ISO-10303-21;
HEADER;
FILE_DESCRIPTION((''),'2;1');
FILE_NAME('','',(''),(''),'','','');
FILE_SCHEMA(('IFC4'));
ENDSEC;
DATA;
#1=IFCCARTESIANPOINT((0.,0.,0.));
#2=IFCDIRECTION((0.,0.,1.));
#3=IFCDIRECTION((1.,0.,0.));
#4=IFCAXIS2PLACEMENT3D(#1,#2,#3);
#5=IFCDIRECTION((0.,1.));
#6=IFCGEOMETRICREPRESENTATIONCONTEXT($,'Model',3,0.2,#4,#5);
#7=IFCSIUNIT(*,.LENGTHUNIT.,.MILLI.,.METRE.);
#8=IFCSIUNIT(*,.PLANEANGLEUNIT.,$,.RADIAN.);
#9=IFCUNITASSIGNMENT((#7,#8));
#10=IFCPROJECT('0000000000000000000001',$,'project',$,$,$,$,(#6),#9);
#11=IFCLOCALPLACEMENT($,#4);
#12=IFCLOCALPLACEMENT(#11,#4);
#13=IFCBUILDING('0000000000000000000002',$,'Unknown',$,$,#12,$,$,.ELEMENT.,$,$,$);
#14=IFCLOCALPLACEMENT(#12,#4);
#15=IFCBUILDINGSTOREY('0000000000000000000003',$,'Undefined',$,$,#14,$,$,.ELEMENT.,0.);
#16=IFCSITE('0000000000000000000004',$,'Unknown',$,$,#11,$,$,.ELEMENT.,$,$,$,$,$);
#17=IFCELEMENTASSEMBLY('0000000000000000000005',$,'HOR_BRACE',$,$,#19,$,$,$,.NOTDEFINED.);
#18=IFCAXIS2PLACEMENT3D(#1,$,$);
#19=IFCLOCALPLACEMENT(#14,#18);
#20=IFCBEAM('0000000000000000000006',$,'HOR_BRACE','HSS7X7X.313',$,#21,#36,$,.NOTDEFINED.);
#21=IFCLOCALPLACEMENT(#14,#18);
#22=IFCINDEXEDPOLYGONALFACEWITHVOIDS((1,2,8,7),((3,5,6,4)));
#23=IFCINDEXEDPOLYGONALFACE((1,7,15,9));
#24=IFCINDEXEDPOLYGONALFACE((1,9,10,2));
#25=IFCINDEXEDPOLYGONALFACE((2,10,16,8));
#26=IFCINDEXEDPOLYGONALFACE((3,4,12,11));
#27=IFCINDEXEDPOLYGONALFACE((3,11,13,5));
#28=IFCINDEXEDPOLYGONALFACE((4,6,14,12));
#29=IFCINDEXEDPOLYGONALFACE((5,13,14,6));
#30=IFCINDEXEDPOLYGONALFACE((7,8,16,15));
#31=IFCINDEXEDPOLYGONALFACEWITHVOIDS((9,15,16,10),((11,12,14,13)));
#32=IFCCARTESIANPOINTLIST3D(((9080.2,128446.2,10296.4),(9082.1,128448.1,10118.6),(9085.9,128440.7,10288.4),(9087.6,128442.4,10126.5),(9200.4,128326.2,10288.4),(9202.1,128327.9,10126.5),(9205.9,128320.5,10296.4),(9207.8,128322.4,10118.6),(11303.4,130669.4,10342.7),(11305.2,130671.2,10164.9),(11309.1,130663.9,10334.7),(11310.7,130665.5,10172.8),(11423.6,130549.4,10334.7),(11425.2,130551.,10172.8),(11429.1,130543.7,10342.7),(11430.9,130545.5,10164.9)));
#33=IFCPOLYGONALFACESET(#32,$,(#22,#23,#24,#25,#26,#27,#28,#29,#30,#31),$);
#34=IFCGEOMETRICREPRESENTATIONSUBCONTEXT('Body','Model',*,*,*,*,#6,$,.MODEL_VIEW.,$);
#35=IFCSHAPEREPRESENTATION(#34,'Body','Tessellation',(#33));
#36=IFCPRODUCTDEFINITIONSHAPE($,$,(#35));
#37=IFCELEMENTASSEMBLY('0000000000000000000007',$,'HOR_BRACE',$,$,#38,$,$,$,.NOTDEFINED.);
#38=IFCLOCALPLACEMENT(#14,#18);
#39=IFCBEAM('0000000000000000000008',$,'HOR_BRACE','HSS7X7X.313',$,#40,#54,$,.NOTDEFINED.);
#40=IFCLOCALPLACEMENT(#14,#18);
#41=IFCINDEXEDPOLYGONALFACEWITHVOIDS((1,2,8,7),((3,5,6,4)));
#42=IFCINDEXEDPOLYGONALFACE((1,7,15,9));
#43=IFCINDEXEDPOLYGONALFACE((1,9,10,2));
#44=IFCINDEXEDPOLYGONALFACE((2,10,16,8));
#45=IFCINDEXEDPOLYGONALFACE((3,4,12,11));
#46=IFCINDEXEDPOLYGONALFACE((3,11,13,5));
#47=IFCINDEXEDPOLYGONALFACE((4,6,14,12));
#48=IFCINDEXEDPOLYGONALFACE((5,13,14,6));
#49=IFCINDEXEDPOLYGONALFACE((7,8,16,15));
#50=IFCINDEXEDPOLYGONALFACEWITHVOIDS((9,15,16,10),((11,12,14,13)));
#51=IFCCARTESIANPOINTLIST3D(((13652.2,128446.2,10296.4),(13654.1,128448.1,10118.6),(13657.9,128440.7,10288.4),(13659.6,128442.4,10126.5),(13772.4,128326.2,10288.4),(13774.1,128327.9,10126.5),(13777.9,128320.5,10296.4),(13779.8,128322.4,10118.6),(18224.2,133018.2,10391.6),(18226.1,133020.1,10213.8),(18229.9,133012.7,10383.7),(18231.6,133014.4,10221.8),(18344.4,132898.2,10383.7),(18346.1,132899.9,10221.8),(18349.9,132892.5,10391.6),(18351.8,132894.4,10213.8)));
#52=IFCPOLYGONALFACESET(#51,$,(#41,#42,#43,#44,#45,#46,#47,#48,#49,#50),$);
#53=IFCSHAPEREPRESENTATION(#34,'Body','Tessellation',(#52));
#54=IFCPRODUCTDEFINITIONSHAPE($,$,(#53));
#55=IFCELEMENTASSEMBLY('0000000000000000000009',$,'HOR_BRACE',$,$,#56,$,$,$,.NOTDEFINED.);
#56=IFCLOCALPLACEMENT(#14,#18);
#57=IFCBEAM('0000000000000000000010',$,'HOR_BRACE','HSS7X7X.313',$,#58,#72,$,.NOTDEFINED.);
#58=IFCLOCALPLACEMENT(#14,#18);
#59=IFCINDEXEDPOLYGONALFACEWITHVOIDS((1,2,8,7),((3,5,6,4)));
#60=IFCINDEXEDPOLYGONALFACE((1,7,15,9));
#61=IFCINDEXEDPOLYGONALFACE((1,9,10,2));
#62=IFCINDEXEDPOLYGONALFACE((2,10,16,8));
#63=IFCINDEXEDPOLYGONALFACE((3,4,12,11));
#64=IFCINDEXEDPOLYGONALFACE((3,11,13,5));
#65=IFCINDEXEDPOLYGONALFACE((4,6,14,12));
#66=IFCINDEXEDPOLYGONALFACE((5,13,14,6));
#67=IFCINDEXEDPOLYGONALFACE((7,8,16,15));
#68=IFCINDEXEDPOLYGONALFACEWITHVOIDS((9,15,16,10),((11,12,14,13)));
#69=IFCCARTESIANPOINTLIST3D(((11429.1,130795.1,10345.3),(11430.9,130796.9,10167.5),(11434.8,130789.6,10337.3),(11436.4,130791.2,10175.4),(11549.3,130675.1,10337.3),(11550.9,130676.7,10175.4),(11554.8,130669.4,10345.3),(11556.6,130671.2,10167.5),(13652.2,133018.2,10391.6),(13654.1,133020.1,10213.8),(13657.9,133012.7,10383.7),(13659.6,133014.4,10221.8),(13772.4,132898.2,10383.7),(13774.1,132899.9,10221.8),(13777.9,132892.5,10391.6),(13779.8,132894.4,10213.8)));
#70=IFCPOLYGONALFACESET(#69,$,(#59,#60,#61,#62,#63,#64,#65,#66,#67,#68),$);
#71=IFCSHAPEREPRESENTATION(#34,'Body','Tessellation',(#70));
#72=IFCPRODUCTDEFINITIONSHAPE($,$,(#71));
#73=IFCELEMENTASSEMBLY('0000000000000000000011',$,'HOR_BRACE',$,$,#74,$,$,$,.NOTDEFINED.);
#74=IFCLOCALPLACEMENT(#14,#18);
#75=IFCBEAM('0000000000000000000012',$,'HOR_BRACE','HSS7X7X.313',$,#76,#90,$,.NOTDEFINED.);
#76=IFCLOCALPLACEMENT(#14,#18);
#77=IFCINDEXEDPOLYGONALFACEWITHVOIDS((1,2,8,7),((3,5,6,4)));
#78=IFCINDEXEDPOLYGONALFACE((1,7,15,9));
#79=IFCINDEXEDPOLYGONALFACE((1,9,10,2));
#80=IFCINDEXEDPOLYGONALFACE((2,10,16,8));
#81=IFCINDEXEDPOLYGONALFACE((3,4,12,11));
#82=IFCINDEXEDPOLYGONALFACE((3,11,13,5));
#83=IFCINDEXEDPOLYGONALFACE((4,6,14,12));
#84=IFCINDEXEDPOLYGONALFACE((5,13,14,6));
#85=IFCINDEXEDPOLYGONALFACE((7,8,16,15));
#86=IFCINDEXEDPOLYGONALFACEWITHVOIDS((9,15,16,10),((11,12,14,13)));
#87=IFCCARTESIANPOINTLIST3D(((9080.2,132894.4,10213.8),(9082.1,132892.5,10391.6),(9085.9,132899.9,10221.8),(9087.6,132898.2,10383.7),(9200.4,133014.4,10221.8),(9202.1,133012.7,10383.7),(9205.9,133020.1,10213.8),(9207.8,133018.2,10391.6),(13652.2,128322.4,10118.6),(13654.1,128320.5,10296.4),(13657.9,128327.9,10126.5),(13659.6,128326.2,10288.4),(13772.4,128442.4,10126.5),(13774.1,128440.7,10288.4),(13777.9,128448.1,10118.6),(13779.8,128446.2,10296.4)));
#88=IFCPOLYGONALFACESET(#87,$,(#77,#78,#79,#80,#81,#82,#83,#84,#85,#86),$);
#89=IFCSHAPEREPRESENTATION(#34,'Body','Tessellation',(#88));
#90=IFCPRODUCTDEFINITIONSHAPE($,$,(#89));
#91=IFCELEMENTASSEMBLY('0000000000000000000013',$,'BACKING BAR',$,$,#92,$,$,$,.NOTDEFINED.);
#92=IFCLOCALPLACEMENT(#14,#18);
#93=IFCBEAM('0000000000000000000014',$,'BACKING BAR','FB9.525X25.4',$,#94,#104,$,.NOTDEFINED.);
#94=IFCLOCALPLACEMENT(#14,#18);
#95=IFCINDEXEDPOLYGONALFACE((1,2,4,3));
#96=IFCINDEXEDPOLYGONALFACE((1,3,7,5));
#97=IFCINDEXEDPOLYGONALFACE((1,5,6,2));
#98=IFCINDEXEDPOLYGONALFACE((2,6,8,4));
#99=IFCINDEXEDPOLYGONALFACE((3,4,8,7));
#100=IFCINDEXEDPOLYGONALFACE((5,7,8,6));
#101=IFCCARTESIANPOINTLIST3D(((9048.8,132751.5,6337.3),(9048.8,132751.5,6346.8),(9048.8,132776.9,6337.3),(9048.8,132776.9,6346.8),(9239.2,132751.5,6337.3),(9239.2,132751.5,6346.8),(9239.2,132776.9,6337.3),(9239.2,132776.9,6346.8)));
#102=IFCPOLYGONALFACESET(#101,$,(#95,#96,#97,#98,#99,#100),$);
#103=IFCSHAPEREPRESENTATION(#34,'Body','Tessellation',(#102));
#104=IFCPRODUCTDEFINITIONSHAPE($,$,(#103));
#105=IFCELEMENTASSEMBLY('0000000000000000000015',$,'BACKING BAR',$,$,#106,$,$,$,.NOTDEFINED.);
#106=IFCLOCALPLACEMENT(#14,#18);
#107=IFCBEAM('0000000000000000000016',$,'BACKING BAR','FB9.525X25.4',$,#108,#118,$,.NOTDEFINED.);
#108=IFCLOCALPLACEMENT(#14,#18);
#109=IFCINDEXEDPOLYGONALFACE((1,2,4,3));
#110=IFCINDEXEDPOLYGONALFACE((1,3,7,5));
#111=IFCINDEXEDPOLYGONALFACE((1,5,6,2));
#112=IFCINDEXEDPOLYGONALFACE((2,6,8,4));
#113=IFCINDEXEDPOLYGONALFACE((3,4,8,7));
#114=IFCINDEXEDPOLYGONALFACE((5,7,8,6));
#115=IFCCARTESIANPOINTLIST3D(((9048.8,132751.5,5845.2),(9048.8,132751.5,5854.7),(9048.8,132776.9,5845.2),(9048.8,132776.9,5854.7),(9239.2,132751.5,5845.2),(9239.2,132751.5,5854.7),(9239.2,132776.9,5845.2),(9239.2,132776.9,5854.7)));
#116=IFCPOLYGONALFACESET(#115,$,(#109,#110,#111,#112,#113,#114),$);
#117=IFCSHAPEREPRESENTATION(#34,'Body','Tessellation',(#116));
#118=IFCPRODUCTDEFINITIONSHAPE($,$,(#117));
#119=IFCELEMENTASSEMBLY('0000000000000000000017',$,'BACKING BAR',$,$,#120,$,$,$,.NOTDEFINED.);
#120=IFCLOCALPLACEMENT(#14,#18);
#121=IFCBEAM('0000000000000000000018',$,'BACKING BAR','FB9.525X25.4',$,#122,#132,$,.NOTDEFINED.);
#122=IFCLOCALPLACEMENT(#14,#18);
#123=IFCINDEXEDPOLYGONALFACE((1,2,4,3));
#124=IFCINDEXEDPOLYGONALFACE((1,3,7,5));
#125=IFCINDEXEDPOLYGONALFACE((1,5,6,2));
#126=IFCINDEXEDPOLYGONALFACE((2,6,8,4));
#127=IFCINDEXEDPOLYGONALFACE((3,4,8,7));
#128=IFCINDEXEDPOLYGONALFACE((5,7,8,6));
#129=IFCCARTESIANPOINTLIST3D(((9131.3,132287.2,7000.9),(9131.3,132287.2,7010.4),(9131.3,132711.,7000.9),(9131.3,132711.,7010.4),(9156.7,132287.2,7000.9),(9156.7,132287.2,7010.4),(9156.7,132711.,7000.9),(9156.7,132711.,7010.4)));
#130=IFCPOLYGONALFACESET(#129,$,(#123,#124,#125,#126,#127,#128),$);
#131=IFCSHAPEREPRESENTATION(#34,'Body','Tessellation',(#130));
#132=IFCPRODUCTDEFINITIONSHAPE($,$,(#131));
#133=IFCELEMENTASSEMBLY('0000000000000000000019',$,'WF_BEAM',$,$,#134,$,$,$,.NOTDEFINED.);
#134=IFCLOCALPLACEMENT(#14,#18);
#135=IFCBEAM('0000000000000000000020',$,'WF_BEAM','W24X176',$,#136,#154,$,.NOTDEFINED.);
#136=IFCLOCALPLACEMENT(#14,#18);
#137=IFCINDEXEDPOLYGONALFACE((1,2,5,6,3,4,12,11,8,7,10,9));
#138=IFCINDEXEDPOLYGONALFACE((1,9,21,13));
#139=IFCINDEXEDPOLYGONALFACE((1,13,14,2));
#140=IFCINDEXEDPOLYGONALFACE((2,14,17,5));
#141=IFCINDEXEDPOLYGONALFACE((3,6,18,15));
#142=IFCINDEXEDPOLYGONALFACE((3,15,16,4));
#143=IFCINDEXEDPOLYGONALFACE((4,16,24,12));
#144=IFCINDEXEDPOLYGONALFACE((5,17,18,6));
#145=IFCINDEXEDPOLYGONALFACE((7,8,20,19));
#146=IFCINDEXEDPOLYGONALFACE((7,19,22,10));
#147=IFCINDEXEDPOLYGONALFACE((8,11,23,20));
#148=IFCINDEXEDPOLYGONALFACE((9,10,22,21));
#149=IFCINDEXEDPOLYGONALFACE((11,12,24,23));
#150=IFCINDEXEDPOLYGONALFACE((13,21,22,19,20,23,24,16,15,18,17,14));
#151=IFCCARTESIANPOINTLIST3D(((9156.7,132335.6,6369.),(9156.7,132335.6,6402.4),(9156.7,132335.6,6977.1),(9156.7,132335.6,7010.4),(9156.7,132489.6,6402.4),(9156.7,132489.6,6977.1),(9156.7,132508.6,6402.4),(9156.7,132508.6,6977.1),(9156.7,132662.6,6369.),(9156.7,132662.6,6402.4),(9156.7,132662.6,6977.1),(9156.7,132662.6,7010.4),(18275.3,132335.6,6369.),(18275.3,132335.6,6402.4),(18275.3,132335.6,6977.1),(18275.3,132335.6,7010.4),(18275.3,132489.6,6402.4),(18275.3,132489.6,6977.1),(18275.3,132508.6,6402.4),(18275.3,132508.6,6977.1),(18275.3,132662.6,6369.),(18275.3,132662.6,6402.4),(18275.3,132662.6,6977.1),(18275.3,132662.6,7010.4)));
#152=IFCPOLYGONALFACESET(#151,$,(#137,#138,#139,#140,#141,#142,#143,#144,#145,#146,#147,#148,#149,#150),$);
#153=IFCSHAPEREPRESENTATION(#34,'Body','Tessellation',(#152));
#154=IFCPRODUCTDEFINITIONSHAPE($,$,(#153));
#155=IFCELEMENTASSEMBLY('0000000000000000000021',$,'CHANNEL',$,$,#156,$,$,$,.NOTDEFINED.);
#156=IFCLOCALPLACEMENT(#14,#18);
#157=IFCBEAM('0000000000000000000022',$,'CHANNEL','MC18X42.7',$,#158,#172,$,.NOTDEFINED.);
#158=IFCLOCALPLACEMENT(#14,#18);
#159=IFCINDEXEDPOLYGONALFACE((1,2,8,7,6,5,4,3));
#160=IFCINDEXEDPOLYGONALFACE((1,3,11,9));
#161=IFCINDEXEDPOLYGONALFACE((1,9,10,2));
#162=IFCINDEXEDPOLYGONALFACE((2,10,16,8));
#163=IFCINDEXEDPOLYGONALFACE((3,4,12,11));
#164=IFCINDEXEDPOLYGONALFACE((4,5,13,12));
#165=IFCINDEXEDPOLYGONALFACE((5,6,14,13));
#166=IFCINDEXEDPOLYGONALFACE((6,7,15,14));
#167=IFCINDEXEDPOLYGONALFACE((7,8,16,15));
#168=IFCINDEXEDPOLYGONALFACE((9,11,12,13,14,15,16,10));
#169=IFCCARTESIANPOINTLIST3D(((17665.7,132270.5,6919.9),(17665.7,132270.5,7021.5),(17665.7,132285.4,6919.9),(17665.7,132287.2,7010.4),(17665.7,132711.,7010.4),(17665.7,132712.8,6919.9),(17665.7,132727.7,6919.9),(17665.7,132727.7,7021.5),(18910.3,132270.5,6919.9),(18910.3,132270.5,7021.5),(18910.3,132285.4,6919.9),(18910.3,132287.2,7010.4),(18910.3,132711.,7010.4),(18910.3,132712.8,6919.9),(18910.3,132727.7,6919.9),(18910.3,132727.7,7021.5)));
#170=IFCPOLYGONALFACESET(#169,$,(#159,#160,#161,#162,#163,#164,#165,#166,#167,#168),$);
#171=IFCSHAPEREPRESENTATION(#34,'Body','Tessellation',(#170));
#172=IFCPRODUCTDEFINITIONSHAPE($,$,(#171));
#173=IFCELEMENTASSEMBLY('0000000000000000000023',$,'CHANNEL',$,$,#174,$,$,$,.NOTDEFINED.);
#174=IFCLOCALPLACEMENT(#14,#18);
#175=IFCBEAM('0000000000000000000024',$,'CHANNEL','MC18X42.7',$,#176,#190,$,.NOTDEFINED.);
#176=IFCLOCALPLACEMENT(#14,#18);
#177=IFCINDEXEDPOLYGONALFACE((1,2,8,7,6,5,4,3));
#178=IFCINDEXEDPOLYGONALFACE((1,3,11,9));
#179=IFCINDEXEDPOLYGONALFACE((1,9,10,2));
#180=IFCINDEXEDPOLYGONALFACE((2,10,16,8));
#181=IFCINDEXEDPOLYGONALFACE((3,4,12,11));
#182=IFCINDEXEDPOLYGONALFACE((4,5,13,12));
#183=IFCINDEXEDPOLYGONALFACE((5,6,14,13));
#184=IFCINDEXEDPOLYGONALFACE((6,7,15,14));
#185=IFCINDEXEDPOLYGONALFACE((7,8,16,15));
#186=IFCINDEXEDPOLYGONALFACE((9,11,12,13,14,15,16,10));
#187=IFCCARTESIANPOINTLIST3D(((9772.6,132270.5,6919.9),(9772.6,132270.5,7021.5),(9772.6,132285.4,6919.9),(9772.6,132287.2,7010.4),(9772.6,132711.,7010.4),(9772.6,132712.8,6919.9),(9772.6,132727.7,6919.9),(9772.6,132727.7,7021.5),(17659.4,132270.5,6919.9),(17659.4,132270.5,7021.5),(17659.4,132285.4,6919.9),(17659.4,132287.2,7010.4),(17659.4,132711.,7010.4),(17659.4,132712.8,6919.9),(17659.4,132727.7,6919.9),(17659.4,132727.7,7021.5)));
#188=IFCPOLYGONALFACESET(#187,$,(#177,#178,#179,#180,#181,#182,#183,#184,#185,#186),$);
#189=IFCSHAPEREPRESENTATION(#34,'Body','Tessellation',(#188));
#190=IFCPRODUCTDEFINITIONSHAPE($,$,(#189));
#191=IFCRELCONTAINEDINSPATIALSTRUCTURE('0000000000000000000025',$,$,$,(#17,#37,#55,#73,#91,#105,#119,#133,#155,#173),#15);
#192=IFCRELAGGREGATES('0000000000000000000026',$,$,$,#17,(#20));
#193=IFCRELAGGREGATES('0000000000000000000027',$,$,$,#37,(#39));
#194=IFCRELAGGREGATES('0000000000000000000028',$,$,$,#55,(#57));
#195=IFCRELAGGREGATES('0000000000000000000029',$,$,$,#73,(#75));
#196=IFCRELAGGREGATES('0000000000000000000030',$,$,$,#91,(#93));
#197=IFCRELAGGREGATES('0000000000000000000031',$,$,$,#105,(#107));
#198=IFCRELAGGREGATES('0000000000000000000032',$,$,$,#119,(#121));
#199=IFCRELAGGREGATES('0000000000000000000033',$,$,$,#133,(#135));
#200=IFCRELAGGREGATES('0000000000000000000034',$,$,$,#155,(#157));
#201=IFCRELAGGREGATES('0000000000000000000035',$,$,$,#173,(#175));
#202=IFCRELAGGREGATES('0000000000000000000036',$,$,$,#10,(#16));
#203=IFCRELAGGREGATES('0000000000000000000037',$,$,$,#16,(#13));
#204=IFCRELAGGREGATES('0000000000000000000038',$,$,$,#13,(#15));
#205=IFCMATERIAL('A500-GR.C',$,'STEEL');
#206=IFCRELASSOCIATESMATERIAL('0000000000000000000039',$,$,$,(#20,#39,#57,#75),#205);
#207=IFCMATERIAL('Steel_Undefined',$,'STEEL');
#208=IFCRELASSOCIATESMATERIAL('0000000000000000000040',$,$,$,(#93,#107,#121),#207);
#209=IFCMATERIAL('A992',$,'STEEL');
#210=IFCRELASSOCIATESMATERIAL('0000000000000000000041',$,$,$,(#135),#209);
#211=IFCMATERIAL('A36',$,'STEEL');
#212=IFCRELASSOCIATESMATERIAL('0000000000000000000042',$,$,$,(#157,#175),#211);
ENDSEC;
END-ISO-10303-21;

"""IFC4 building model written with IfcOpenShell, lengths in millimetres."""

from ifc_helpers import new_model, si_unit, direction, frame, origin_with_axes, place, context, subcontext, project, spatial, line, indexed_curve, outline, extrude, material, element, aggregate, save


model = new_model("IFC4")

# Units and contexts
model_context = context("Model", 3, precision=0.2, world=origin_with_axes(), true_north=direction((0.0, 1.0)))
body_context = subcontext(model_context, "Body", "Model", "MODEL_VIEW")
ifc_project = project(units=[si_unit("LENGTHUNIT", "METRE", prefix="MILLI"), si_unit("PLANEANGLEUNIT", "RADIAN")], contexts=[model_context])

# Site, building, storey
site_placement = place(None, origin_with_axes())
site = spatial("IfcSite", under=ifc_project, at=site_placement, Name="Unknown", CompositionType="ELEMENT")
building_placement = place(site_placement, origin_with_axes())
building = spatial("IfcBuilding", under=site, at=building_placement, Name="Unknown", CompositionType="ELEMENT")
storey_placement = place(building_placement, origin_with_axes())
storey = spatial("IfcBuildingStorey", under=building, at=storey_placement, Name="Undefined", CompositionType="ELEMENT", Elevation=0.0)

# Shared definitions
ifc_material_1 = material(Name="A992", Category="STEEL")
ifc_material_2 = material(Name="A500-GR.C", Category="STEEL")

# Element assemblies, beams
assembly_1_placement = place(storey_placement, frame((9144.0, 128384.3, 10207.5), z_axis=(0.707107, -0.707107, 0.0), x_axis=(0.70703, 0.70703, 0.01473)))
assembly_1 = element("IfcElementAssembly", 1, at=assembly_1_placement, inside=storey, Name="HOR_BRACE", PredefinedType="NOTDEFINED")
beam_1_placement = place(assembly_1_placement, origin_with_axes())
beam_1 = element("IfcBeam", 2, at=beam_1_placement, material=ifc_material_2, Name="HOR_BRACE", Description="HSS7X7X.313", PredefinedType="NOTDEFINED", context=body_context, shape_type="SolidModel", body=[
    extrude(outline(indexed_curve([(-88.9, -88.9), (88.9, -88.9), (88.9, 88.9), (-88.9, 88.9)], segments=[line(1, 2, 3, 4, 1)]), holes=[indexed_curve([(-81.0, -81.0), (-81.0, 81.0), (81.0, 81.0), (81.0, -81.0)], segments=[line(1, 2, 3, 4, 1)])]), frame((0.0, 0.0, 0.0), z_axis=(-1.0, 0.0, 0.0), x_axis=(0.0, 0.0, 1.0)), (0.0, 0.0, -1.0), 3144.3),
])
aggregate(assembly_1, [beam_1])
assembly_2_placement = place(storey_placement, frame((13716.0, 128384.3, 10207.5), z_axis=(0.707107, -0.707107, 0.0), x_axis=(0.70703, 0.70703, 0.01473)))
assembly_2 = element("IfcElementAssembly", 3, at=assembly_2_placement, inside=storey, Name="HOR_BRACE", PredefinedType="NOTDEFINED")
beam_2_placement = place(assembly_2_placement, origin_with_axes())
beam_2 = element("IfcBeam", 4, at=beam_2_placement, material=ifc_material_2, Name="HOR_BRACE", Description="HSS7X7X.313", PredefinedType="NOTDEFINED", context=body_context, shape_type="SolidModel", body=[
    extrude(outline(indexed_curve([(-88.9, -88.9), (88.9, -88.9), (88.9, 88.9), (-88.9, 88.9)], segments=[line(1, 2, 3, 4, 1)]), holes=[indexed_curve([(-81.0, -81.0), (-81.0, 81.0), (81.0, 81.0), (81.0, -81.0)], segments=[line(1, 2, 3, 4, 1)])]), frame((0.0, 0.0, 0.0), z_axis=(-1.0, 0.0, 0.0), x_axis=(0.0, 0.0, 1.0)), (0.0, 0.0, -1.0), 6466.5),
])
aggregate(assembly_2, [beam_2])
assembly_3_placement = place(storey_placement, frame((11492.9, 130733.2, 10256.4), z_axis=(0.707107, -0.707107, 0.0), x_axis=(0.70703, 0.70703, 0.01473)))
assembly_3 = element("IfcElementAssembly", 5, at=assembly_3_placement, inside=storey, Name="HOR_BRACE", PredefinedType="NOTDEFINED")
beam_3_placement = place(assembly_3_placement, origin_with_axes())
beam_3 = element("IfcBeam", 6, at=beam_3_placement, material=ifc_material_2, Name="HOR_BRACE", Description="HSS7X7X.313", PredefinedType="NOTDEFINED", context=body_context, shape_type="SolidModel", body=[
    extrude(outline(indexed_curve([(-88.9, -88.9), (88.9, -88.9), (88.9, 88.9), (-88.9, 88.9)], segments=[line(1, 2, 3, 4, 1)]), holes=[indexed_curve([(-81.0, -81.0), (-81.0, 81.0), (81.0, 81.0), (81.0, -81.0)], segments=[line(1, 2, 3, 4, 1)])]), frame((0.0, 0.0, 0.0), z_axis=(-1.0, 0.0, 0.0), x_axis=(0.0, 0.0, 1.0)), (0.0, 0.0, -1.0), 3144.3),
])
aggregate(assembly_3, [beam_3])
assembly_4_placement = place(storey_placement, frame((13716.0, 128384.3, 10207.5), z_axis=(0.707107, 0.707107, 0.0), x_axis=(-0.70703, 0.70703, 0.01473)))
assembly_4 = element("IfcElementAssembly", 7, at=assembly_4_placement, inside=storey, Name="HOR_BRACE", PredefinedType="NOTDEFINED")
beam_4_placement = place(assembly_4_placement, origin_with_axes())
beam_4 = element("IfcBeam", 8, at=beam_4_placement, material=ifc_material_2, Name="HOR_BRACE", Description="HSS7X7X.313", PredefinedType="NOTDEFINED", context=body_context, shape_type="SolidModel", body=[
    extrude(outline(indexed_curve([(-88.9, -88.9), (88.9, -88.9), (88.9, 88.9), (-88.9, 88.9)], segments=[line(1, 2, 3, 4, 1)]), holes=[indexed_curve([(-81.0, -81.0), (-81.0, 81.0), (81.0, 81.0), (81.0, -81.0)], segments=[line(1, 2, 3, 4, 1)])]), frame((0.0, 0.0, 0.0), z_axis=(-1.0, 0.0, 0.0), x_axis=(0.0, 0.0, 1.0)), (0.0, 0.0, -1.0), 6466.5),
])
aggregate(assembly_4, [beam_4])
assembly_5_placement = place(storey_placement, frame((9239.2, 132764.2, 6342.1), z_axis=(0.0, 0.0, 1.0), x_axis=(-1.0, 0.0, 0.0)))
assembly_5 = element("IfcElementAssembly", 9, at=assembly_5_placement, inside=storey, Name="BACKING BAR", PredefinedType="NOTDEFINED")
ifc_material_3 = material(Name="Steel_Undefined", Category="STEEL")
beam_5_placement = place(assembly_5_placement, origin_with_axes())
beam_5 = element("IfcBeam", 10, at=beam_5_placement, material=ifc_material_3, Name="BACKING BAR", Description="FB9.525X25.4", PredefinedType="NOTDEFINED", context=body_context, shape_type="SolidModel", body=[
    extrude(outline(indexed_curve([(-4.8, -12.7), (4.8, -12.7), (4.8, 12.7), (-4.8, 12.7)], segments=[line(1, 2, 3, 4, 1)])), frame((0.0, 0.0, 0.0), z_axis=(-1.0, 0.0, 0.0), x_axis=(0.0, 0.0, 1.0)), (0.0, 0.0, -1.0), 190.5),
])
aggregate(assembly_5, [beam_5])
assembly_6_placement = place(storey_placement, frame((9239.2, 132764.2, 5849.9), z_axis=(0.0, 0.0, 1.0), x_axis=(-1.0, 0.0, 0.0)))
assembly_6 = element("IfcElementAssembly", 11, at=assembly_6_placement, inside=storey, Name="BACKING BAR", PredefinedType="NOTDEFINED")
beam_6_placement = place(assembly_6_placement, origin_with_axes())
beam_6 = element("IfcBeam", 12, at=beam_6_placement, material=ifc_material_3, Name="BACKING BAR", Description="FB9.525X25.4", PredefinedType="NOTDEFINED", context=body_context, shape_type="SolidModel", body=[
    extrude(outline(indexed_curve([(-4.8, -12.7), (4.8, -12.7), (4.8, 12.7), (-4.8, 12.7)], segments=[line(1, 2, 3, 4, 1)])), frame((0.0, 0.0, 0.0), z_axis=(-1.0, 0.0, 0.0), x_axis=(0.0, 0.0, 1.0)), (0.0, 0.0, -1.0), 190.5),
])
aggregate(assembly_6, [beam_6])
assembly_7_placement = place(storey_placement, frame((9144.0, 132711.0, 7005.6), z_axis=(0.0, 0.0, 1.0), x_axis=(0.0, -1.0, 0.0)))
assembly_7 = element("IfcElementAssembly", 13, at=assembly_7_placement, inside=storey, Name="BACKING BAR", PredefinedType="NOTDEFINED")
beam_7_placement = place(assembly_7_placement, origin_with_axes())
beam_7 = element("IfcBeam", 14, at=beam_7_placement, material=ifc_material_3, Name="BACKING BAR", Description="FB9.525X25.4", PredefinedType="NOTDEFINED", context=body_context, shape_type="SolidModel", body=[
    extrude(outline(indexed_curve([(-4.8, -12.7), (4.8, -12.7), (4.8, 12.7), (-4.8, 12.7)], segments=[line(1, 2, 3, 4, 1)])), frame((0.0, 0.0, 0.0), z_axis=(-1.0, 0.0, 0.0), x_axis=(0.0, 0.0, 1.0)), (0.0, 0.0, -1.0), 423.9),
])
aggregate(assembly_7, [beam_7])
assembly_8_placement = place(storey_placement, frame((9156.7, 132499.1, 6689.7), z_axis=(0.0, -1.0, 0.0), x_axis=(1.0, 0.0, 0.0)))
assembly_8 = element("IfcElementAssembly", 15, at=assembly_8_placement, inside=storey, Name="WF_BEAM", PredefinedType="NOTDEFINED")
beam_8_placement = place(assembly_8_placement, origin_with_axes())
beam_8 = element("IfcBeam", 16, at=beam_8_placement, material=ifc_material_1, Name="WF_BEAM", Description="W24X176", PredefinedType="NOTDEFINED", context=body_context, shape_type="SolidModel", body=[
    extrude(outline(indexed_curve([(-163.5, -320.7), (163.5, -320.7), (163.5, -287.3), (9.5, -287.3), (9.5, 287.3), (163.5, 287.3), (163.5, 320.7), (-163.5, 320.7), (-163.5, 287.3), (-9.5, 287.3), (-9.5, -287.3), (-163.5, -287.3)], segments=[line(1, 2, 3, 4, 5, 6, 7, 8, 9, 10, 11, 12, 1)])), frame((0.0, 0.0, 0.0), z_axis=(-1.0, 0.0, 0.0), x_axis=(0.0, 0.0, 1.0)), (0.0, 0.0, -1.0), 9118.6),
])
aggregate(assembly_8, [beam_8])
assembly_9_placement = place(storey_placement, frame((17665.7, 132499.1, 6970.7), z_axis=(0.0, 0.0, -1.0), x_axis=(1.0, 0.0, 0.0)))
assembly_9 = element("IfcElementAssembly", 17, at=assembly_9_placement, inside=storey, Name="CHANNEL", PredefinedType="NOTDEFINED")
ifc_material_4 = material(Name="A36", Category="STEEL")
beam_9_placement = place(assembly_9_placement, origin_with_axes())
beam_9 = element("IfcBeam", 18, at=beam_9_placement, material=ifc_material_4, Name="CHANNEL", Description="MC18X42.7", PredefinedType="NOTDEFINED", context=body_context, shape_type="SolidModel", body=[
    extrude(outline(indexed_curve([(-50.8, -228.6), (50.8, -228.6), (50.8, -213.7), (-39.7, -211.9), (-39.7, 211.9), (50.8, 213.7), (50.8, 228.6), (-50.8, 228.6)], segments=[line(1, 2, 3, 4, 5, 6, 7, 8, 1)])), frame((0.0, 0.0, 0.0), z_axis=(-1.0, 0.0, 0.0), x_axis=(0.0, 0.0, 1.0)), (0.0, 0.0, -1.0), 1244.6),
])
aggregate(assembly_9, [beam_9])
assembly_10_placement = place(storey_placement, frame((17659.3, 132499.1, 6970.7), z_axis=(0.0, 0.0, -1.0), x_axis=(-1.0, 0.0, 0.0)))
assembly_10 = element("IfcElementAssembly", 19, at=assembly_10_placement, inside=storey, Name="CHANNEL", PredefinedType="NOTDEFINED")
beam_10_placement = place(assembly_10_placement, origin_with_axes())
beam_10 = element("IfcBeam", 20, at=beam_10_placement, material=ifc_material_4, Name="CHANNEL", Description="MC18X42.7", PredefinedType="NOTDEFINED", context=body_context, shape_type="SolidModel", body=[
    extrude(outline(indexed_curve([(-50.8, -228.6), (50.8, -228.6), (50.8, -213.7), (-39.7, -211.9), (-39.7, 211.9), (50.8, 213.7), (50.8, 228.6), (-50.8, 228.6)], segments=[line(1, 2, 3, 4, 5, 6, 7, 8, 1)])), frame((0.0, 0.0, 0.0), z_axis=(-1.0, 0.0, 0.0), x_axis=(0.0, 0.0, 1.0)), (0.0, 0.0, -1.0), 7886.7),
])
aggregate(assembly_10, [beam_10])

save(model, "model.ifc")
